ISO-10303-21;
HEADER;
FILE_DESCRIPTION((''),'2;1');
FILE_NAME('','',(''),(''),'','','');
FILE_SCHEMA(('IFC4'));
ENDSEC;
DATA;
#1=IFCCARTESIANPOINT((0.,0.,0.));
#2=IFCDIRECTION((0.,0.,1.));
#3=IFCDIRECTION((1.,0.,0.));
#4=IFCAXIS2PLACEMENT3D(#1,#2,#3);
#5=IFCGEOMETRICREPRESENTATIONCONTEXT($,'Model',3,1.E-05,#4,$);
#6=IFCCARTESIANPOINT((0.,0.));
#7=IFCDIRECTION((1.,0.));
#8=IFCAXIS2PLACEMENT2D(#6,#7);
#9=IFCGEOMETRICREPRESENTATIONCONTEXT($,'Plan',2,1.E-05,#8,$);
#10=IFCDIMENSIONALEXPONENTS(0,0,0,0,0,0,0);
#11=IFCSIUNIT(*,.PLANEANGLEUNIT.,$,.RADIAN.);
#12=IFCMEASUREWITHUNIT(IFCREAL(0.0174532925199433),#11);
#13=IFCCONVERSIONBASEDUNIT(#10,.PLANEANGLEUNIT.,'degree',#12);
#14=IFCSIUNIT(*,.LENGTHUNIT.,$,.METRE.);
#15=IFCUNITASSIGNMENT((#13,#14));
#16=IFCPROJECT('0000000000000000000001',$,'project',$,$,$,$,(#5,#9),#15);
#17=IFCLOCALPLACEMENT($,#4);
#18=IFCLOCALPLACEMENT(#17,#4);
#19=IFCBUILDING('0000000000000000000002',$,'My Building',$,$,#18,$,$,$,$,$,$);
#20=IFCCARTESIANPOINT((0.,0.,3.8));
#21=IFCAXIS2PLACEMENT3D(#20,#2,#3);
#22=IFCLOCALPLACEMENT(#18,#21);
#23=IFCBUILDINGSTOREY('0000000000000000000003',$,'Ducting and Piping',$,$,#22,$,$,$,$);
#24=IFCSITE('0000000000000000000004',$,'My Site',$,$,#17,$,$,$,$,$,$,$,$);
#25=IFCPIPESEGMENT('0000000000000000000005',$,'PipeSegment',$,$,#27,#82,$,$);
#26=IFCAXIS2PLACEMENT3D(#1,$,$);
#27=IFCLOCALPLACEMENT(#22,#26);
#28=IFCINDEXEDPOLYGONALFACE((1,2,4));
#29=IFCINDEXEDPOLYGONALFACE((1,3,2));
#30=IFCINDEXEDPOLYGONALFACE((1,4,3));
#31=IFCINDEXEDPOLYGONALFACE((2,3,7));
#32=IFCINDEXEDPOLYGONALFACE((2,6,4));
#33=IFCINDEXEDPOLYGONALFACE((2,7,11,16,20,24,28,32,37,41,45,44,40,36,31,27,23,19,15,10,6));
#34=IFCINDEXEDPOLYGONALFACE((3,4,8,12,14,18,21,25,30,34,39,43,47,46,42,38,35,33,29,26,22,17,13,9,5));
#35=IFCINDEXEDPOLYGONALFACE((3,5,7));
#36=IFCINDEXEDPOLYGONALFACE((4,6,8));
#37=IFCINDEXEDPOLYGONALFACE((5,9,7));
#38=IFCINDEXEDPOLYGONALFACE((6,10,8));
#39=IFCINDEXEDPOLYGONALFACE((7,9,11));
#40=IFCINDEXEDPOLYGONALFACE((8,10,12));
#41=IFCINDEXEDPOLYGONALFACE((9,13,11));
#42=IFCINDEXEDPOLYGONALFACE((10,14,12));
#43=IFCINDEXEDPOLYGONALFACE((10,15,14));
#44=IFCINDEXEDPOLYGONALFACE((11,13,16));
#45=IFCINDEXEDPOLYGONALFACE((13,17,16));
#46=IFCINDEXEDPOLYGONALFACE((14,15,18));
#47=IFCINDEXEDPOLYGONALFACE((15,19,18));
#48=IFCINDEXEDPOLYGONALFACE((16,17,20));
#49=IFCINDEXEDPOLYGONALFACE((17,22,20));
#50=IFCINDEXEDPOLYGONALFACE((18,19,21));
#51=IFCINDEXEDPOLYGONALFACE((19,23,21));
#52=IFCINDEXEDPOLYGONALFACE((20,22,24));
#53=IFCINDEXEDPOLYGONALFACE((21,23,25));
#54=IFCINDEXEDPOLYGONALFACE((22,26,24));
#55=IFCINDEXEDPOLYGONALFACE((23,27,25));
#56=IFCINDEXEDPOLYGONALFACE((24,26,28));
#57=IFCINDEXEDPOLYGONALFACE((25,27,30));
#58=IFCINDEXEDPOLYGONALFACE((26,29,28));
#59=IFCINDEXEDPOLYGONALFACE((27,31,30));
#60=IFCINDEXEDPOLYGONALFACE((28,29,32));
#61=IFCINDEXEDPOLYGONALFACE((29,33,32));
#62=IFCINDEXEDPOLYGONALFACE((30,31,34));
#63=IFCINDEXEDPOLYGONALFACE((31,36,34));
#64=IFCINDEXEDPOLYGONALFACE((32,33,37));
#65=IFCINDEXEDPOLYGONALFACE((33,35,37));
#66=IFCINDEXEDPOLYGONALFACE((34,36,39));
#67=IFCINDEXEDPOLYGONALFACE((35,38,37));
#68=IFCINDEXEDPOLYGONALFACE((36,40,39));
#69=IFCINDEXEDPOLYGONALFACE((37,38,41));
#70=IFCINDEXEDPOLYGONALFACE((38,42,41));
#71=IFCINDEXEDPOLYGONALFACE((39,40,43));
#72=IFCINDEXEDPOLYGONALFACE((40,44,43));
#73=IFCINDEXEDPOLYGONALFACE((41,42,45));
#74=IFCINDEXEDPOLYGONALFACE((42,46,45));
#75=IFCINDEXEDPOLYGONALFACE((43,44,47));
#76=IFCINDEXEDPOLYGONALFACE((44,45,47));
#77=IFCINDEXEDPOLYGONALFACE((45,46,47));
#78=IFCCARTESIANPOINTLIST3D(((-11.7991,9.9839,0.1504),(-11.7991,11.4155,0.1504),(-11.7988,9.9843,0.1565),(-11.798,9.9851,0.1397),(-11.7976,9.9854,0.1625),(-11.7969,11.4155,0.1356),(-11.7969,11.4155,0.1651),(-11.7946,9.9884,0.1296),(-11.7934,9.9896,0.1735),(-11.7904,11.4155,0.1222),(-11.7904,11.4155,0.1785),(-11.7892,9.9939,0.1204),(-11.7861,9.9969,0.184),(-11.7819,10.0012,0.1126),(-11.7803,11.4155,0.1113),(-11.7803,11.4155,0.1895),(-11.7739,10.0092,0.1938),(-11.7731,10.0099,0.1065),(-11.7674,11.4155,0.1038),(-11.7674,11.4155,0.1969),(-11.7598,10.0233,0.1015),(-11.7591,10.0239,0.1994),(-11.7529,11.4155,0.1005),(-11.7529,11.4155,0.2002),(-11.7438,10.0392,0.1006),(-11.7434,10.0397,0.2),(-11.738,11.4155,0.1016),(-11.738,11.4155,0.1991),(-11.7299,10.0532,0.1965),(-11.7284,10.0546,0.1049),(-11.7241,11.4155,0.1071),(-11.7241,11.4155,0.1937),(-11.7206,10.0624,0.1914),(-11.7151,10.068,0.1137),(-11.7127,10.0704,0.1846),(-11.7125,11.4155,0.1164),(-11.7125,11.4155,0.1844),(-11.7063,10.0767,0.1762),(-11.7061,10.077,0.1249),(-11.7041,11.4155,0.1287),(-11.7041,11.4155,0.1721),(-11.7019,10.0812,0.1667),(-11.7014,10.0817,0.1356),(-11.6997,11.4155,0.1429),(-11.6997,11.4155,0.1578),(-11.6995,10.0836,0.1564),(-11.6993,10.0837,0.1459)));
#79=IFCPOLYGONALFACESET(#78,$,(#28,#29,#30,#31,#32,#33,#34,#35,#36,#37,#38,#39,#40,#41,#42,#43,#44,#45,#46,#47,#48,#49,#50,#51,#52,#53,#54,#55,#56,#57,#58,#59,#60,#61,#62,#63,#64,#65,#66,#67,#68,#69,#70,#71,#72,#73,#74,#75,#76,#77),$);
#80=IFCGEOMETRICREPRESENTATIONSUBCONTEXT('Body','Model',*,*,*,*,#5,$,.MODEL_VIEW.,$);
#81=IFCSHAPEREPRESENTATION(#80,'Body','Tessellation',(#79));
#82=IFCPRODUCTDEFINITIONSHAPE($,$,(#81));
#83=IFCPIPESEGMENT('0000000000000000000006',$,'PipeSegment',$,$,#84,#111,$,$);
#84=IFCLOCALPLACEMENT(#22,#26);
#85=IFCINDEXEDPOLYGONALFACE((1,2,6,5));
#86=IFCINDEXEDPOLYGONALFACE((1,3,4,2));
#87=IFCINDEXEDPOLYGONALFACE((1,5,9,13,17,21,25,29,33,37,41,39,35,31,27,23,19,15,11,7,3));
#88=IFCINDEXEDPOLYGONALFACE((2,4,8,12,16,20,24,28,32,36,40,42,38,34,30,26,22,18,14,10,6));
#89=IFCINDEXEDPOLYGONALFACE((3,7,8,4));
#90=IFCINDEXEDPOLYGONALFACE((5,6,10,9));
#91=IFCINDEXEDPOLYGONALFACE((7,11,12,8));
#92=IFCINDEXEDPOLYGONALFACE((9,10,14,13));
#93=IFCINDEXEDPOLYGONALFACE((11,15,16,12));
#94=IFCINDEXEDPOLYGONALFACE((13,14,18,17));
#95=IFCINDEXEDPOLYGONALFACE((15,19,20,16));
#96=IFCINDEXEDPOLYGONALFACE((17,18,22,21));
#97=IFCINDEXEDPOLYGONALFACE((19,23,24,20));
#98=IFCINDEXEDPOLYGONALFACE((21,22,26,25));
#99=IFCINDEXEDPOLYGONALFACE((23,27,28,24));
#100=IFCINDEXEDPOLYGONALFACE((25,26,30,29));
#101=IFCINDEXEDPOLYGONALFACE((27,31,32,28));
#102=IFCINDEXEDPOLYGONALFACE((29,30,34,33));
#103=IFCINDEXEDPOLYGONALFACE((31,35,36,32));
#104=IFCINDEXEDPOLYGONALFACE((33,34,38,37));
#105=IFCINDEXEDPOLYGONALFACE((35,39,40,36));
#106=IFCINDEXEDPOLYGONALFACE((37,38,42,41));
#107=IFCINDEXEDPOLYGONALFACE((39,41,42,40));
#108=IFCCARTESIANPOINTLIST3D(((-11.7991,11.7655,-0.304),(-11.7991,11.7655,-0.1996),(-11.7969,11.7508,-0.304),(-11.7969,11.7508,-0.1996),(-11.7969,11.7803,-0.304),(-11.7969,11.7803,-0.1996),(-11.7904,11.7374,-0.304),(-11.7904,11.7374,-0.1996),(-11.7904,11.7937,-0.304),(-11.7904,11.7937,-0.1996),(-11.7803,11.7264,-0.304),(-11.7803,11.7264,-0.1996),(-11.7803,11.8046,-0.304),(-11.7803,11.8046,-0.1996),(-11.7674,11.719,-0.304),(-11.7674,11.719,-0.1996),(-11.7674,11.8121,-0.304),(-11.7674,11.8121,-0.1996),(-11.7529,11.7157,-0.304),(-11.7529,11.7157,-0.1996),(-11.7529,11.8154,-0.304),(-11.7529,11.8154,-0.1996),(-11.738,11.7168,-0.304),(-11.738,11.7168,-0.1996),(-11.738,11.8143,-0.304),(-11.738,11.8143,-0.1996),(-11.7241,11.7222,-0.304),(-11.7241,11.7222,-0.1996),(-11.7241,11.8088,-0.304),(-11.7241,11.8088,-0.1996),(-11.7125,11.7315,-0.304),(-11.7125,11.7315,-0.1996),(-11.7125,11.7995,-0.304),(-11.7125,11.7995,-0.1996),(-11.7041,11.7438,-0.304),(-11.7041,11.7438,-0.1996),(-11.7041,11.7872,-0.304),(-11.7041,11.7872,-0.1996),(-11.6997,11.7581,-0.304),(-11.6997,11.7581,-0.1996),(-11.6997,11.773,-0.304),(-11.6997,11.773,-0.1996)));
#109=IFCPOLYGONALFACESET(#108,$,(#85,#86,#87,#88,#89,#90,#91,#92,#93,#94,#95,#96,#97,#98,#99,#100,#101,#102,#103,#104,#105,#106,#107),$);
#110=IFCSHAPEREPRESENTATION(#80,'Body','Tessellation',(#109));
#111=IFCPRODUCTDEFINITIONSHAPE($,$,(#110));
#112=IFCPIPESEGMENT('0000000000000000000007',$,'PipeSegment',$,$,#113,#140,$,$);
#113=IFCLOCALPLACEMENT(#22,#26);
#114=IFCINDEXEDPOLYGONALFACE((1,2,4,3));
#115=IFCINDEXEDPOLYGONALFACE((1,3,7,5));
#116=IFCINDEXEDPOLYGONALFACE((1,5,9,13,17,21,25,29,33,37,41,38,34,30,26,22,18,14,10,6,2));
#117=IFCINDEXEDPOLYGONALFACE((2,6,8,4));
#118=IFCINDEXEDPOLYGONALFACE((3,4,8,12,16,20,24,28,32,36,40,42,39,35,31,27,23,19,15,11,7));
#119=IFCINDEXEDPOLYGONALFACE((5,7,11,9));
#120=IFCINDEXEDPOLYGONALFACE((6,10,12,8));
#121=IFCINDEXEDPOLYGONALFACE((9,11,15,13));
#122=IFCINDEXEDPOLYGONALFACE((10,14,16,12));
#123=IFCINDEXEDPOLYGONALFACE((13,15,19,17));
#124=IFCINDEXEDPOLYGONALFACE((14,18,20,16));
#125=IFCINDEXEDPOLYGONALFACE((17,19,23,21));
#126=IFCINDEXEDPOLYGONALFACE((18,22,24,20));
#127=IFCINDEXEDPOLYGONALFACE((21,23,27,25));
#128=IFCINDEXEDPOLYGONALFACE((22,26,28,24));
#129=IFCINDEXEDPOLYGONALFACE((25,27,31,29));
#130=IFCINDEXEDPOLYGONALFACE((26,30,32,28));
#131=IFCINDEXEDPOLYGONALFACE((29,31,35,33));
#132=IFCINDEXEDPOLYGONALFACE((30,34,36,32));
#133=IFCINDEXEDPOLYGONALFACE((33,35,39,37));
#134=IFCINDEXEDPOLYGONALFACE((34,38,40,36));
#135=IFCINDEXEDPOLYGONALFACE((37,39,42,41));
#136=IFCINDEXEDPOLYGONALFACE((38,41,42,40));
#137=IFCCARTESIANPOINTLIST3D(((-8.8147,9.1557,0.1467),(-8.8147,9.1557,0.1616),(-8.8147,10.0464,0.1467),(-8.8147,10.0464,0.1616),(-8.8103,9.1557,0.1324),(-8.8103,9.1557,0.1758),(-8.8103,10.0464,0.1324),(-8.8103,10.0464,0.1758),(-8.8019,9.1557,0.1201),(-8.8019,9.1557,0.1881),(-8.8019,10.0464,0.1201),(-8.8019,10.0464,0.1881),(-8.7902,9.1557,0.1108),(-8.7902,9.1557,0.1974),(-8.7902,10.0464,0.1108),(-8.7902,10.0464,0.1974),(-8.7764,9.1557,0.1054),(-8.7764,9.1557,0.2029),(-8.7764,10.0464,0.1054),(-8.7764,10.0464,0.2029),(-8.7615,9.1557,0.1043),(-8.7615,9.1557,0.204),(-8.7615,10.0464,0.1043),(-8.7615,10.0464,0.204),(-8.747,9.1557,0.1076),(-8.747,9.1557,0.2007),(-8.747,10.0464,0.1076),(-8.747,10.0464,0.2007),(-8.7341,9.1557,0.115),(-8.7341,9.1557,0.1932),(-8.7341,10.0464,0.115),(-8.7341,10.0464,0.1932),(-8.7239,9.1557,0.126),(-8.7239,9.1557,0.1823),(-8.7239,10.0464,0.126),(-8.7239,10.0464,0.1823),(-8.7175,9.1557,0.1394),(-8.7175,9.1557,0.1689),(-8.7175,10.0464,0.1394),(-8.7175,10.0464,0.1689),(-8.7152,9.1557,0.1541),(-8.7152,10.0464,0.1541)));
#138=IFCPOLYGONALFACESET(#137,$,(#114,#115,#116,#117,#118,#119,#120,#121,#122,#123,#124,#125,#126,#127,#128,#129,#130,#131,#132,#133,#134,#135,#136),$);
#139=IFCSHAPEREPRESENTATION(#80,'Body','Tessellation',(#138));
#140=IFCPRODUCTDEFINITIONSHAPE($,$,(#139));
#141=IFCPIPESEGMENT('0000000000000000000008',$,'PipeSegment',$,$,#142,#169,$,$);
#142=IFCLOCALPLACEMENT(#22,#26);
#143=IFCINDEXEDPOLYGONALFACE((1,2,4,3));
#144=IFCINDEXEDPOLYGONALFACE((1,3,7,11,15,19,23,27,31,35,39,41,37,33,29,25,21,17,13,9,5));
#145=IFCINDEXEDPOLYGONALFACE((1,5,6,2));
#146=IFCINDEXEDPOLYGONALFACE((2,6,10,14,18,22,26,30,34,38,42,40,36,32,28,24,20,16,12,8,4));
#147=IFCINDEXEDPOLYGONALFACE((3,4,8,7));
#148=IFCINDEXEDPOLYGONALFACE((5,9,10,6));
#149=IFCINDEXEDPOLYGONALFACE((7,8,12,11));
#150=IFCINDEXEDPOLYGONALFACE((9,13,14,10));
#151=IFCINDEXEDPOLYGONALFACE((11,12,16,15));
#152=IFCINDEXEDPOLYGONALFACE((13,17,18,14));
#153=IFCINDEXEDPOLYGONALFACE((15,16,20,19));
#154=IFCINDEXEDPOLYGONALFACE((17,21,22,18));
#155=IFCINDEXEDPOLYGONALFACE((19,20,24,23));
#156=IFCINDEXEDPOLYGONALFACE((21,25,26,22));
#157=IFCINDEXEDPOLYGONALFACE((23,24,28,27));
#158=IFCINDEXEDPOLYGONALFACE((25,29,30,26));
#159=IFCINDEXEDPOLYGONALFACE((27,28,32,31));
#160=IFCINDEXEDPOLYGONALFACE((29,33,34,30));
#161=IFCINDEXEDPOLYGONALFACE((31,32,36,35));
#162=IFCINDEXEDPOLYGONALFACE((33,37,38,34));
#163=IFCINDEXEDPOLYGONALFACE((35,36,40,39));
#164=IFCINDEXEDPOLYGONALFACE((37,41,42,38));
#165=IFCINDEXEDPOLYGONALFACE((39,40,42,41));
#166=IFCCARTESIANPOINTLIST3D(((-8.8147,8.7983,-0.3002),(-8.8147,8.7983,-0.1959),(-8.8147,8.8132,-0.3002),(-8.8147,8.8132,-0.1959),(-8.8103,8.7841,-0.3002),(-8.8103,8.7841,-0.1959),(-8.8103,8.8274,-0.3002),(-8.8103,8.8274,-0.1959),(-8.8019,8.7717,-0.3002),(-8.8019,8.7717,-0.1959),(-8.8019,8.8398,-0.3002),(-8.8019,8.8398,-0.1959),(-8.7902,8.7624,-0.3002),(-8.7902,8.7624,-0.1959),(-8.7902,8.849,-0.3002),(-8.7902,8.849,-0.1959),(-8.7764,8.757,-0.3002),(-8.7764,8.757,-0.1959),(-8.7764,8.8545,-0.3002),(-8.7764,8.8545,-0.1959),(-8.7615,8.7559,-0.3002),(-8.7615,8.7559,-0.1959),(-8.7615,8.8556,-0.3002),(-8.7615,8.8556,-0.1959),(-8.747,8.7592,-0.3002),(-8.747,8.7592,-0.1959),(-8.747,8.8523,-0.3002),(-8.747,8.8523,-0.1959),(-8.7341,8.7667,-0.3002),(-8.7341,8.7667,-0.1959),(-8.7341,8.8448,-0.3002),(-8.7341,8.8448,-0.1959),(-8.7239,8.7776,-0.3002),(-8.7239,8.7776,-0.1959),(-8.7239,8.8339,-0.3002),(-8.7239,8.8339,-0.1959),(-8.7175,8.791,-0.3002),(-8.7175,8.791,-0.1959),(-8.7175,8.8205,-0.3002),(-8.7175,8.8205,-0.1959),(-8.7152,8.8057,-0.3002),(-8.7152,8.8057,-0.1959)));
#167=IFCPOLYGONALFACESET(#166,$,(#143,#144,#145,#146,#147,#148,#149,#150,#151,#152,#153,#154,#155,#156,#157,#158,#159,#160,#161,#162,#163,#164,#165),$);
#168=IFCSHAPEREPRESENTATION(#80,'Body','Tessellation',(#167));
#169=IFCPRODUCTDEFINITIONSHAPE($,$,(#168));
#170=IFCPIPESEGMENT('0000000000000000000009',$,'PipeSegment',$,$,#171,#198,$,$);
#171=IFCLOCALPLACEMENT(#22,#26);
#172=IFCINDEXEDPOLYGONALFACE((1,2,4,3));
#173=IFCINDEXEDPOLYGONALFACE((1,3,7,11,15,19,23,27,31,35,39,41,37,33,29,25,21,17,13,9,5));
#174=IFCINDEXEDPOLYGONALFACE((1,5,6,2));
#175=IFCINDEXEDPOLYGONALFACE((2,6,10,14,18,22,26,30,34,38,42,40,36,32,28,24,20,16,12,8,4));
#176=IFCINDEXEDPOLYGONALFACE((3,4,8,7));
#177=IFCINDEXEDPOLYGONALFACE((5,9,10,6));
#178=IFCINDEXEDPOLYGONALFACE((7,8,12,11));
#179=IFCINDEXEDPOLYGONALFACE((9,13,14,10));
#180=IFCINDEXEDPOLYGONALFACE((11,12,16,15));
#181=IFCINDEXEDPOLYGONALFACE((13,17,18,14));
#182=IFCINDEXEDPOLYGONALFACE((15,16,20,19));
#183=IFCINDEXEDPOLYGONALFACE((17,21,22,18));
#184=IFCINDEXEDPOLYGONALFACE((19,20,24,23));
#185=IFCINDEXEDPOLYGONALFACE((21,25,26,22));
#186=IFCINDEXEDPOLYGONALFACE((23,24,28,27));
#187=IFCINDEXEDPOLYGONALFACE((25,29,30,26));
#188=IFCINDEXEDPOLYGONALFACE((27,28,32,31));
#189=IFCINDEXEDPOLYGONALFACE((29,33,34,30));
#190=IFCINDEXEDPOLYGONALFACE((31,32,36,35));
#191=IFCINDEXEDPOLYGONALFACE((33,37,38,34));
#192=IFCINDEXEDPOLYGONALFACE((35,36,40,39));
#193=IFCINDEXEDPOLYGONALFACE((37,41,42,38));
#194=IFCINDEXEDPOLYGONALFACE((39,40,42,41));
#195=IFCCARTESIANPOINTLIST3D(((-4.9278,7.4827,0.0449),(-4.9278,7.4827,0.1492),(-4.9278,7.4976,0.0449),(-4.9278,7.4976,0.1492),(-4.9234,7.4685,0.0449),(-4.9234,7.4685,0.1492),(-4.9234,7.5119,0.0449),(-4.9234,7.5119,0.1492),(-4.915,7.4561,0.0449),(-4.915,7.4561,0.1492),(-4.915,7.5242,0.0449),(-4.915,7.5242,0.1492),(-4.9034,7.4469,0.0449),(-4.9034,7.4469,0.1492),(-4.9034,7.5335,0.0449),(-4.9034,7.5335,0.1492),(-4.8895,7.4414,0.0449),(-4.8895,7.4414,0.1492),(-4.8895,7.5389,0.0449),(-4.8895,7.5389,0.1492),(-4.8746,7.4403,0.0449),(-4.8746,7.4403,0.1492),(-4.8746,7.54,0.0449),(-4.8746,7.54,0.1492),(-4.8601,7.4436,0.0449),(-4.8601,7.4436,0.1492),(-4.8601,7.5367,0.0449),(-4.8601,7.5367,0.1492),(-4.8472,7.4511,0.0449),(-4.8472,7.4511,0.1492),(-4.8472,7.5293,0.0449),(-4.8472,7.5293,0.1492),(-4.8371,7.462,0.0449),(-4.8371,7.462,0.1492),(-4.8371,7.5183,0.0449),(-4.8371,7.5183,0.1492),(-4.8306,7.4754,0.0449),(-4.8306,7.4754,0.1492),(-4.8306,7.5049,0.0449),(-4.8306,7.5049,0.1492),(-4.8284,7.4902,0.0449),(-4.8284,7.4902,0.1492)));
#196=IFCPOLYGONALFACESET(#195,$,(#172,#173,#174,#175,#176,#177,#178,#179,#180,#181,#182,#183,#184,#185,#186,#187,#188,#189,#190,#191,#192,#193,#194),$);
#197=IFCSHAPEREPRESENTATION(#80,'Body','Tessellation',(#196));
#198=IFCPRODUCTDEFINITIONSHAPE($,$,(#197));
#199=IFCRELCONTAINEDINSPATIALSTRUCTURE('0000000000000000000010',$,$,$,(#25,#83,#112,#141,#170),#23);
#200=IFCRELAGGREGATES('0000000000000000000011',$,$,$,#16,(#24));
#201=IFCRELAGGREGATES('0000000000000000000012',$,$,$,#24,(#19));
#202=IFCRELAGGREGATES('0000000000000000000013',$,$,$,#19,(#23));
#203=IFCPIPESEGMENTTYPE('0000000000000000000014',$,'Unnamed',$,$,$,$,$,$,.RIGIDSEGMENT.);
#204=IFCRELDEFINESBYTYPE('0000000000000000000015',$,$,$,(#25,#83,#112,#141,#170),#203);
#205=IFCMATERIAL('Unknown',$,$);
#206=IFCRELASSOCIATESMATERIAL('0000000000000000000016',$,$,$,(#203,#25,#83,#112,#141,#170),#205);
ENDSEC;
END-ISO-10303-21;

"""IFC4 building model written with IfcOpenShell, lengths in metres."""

from ifc_helpers import new_model, entity, si_unit, converted_unit, frame, origin_with_axes, origin_2d_with_axis, place, context, subcontext, project, spatial, circle, extrude, clip, halfspace, material, material_profile, profile_set, profile_usage, type_object, element, save


model = new_model("IFC4")

# Units and contexts
model_context = context("Model", 3, precision=1e-05, world=origin_with_axes())
plan_context = context("Plan", 2, precision=1e-05, world=origin_2d_with_axis())
body_context = subcontext(model_context, "Body", "Model", "MODEL_VIEW")
ifc_project = project(units=[converted_unit("PLANEANGLEUNIT", "degree", entity("IfcReal", 0.0174532925199433), si_unit("PLANEANGLEUNIT", "RADIAN"), dimensions=[0, 0, 0, 0, 0, 0, 0]), si_unit("LENGTHUNIT", "METRE")], contexts=[model_context, plan_context])

# Site, building, storey
site_placement = place(None, origin_with_axes())
site = spatial("IfcSite", under=ifc_project, at=site_placement, Name="My Site")
building_placement = place(site_placement, origin_with_axes())
building = spatial("IfcBuilding", under=site, at=building_placement, Name="My Building")
storey_placement = place(building_placement, frame((0.0, 0.0, 3.8), z_axis=(0.0, 0.0, 1.0), x_axis=(1.0, 0.0, 0.0)))
storey = spatial("IfcBuildingStorey", under=building, at=storey_placement, Name="Ducting and Piping")

# Pipe segments
ifc_material = material(Name="Unknown")
ifc_material_profile_1 = material_profile(ifc_material, circle(Radius=0.05))
ifc_profile_set_1 = profile_set([ifc_material_profile_1])
pipe_segment_type = type_object("IfcPipeSegmentType", Name="Unnamed", PredefinedType="RIGIDSEGMENT", material=ifc_profile_set_1)
ifc_profile_usage_1 = profile_usage(ifc_profile_set_1, cardinal=5)
pipe_segment_1_placement = place(storey_placement, frame((-11.7491, 9.9839, 0.1504), z_axis=(0.0, 1.0, 0.0), x_axis=(-1.0, 0.0, 0.0)))
element("IfcPipeSegment", 1, at=pipe_segment_1_placement, inside=storey, type_object=pipe_segment_type, material=ifc_profile_usage_1, Name="PipeSegment", context=body_context, shape_type="Clipping", body=[
    clip(extrude(circle(Radius=0.05), origin_with_axes(), (0.0, 0.0, 1.0), 1.4316), halfspace(frame((0.05, -3.9831, 0.0), z_axis=(-0.707114, 0.0, -0.7071), x_axis=(0.0, 1.0, 0.0)), False)),
])
ifc_profile_usage_2 = profile_usage(ifc_profile_set_1, cardinal=5)
pipe_segment_2_placement = place(storey_placement, frame((-11.7491, 11.7655, -0.304), z_axis=(0.0, 0.0, 1.0), x_axis=(-1.0, 0.0, 0.0)))
element("IfcPipeSegment", 2, at=pipe_segment_2_placement, inside=storey, type_object=pipe_segment_type, material=ifc_profile_usage_2, Name="PipeSegment", context=body_context, shape_type="SweptSolid", body=[
    extrude(circle(Radius=0.05), origin_with_axes(), (0.0, 0.0, 1.0), 0.1043),
])
ifc_profile_usage_3 = profile_usage(ifc_profile_set_1, cardinal=5)
pipe_segment_3_placement = place(storey_placement, frame((-8.7652, 10.0464, 0.1541), z_axis=(0.0, -1.0, 0.0), x_axis=(1.0, 0.0, 0.0)))
element("IfcPipeSegment", 3, at=pipe_segment_3_placement, inside=storey, type_object=pipe_segment_type, material=ifc_profile_usage_3, Name="PipeSegment", context=body_context, shape_type="SweptSolid", body=[
    extrude(circle(Radius=0.05), origin_with_axes(), (0.0, 0.0, 1.0), 0.8907),
])
ifc_profile_usage_4 = profile_usage(ifc_profile_set_1, cardinal=5)
pipe_segment_4_placement = place(storey_placement, frame((-8.7652, 8.8057, -0.3002), z_axis=(0.0, 0.0, 1.0), x_axis=(1.0, 0.0, 0.0)))
element("IfcPipeSegment", 4, at=pipe_segment_4_placement, inside=storey, type_object=pipe_segment_type, material=ifc_profile_usage_4, Name="PipeSegment", context=body_context, shape_type="SweptSolid", body=[
    extrude(circle(Radius=0.05), origin_with_axes(), (0.0, 0.0, 1.0), 0.1043),
])
ifc_profile_usage_5 = profile_usage(ifc_profile_set_1, cardinal=5)
pipe_segment_5_placement = place(storey_placement, frame((-4.8784, 7.4902, 0.0449), z_axis=(0.0, 0.0, 1.0), x_axis=(1.0, 0.00006, 0.0)))
element("IfcPipeSegment", 5, at=pipe_segment_5_placement, inside=storey, type_object=pipe_segment_type, material=ifc_profile_usage_5, Name="PipeSegment", context=body_context, shape_type="SweptSolid", body=[
    extrude(circle(Radius=0.05), origin_with_axes(), (0.0, 0.0, 1.0), 0.1043),
])

save(model, "model.ifc")
